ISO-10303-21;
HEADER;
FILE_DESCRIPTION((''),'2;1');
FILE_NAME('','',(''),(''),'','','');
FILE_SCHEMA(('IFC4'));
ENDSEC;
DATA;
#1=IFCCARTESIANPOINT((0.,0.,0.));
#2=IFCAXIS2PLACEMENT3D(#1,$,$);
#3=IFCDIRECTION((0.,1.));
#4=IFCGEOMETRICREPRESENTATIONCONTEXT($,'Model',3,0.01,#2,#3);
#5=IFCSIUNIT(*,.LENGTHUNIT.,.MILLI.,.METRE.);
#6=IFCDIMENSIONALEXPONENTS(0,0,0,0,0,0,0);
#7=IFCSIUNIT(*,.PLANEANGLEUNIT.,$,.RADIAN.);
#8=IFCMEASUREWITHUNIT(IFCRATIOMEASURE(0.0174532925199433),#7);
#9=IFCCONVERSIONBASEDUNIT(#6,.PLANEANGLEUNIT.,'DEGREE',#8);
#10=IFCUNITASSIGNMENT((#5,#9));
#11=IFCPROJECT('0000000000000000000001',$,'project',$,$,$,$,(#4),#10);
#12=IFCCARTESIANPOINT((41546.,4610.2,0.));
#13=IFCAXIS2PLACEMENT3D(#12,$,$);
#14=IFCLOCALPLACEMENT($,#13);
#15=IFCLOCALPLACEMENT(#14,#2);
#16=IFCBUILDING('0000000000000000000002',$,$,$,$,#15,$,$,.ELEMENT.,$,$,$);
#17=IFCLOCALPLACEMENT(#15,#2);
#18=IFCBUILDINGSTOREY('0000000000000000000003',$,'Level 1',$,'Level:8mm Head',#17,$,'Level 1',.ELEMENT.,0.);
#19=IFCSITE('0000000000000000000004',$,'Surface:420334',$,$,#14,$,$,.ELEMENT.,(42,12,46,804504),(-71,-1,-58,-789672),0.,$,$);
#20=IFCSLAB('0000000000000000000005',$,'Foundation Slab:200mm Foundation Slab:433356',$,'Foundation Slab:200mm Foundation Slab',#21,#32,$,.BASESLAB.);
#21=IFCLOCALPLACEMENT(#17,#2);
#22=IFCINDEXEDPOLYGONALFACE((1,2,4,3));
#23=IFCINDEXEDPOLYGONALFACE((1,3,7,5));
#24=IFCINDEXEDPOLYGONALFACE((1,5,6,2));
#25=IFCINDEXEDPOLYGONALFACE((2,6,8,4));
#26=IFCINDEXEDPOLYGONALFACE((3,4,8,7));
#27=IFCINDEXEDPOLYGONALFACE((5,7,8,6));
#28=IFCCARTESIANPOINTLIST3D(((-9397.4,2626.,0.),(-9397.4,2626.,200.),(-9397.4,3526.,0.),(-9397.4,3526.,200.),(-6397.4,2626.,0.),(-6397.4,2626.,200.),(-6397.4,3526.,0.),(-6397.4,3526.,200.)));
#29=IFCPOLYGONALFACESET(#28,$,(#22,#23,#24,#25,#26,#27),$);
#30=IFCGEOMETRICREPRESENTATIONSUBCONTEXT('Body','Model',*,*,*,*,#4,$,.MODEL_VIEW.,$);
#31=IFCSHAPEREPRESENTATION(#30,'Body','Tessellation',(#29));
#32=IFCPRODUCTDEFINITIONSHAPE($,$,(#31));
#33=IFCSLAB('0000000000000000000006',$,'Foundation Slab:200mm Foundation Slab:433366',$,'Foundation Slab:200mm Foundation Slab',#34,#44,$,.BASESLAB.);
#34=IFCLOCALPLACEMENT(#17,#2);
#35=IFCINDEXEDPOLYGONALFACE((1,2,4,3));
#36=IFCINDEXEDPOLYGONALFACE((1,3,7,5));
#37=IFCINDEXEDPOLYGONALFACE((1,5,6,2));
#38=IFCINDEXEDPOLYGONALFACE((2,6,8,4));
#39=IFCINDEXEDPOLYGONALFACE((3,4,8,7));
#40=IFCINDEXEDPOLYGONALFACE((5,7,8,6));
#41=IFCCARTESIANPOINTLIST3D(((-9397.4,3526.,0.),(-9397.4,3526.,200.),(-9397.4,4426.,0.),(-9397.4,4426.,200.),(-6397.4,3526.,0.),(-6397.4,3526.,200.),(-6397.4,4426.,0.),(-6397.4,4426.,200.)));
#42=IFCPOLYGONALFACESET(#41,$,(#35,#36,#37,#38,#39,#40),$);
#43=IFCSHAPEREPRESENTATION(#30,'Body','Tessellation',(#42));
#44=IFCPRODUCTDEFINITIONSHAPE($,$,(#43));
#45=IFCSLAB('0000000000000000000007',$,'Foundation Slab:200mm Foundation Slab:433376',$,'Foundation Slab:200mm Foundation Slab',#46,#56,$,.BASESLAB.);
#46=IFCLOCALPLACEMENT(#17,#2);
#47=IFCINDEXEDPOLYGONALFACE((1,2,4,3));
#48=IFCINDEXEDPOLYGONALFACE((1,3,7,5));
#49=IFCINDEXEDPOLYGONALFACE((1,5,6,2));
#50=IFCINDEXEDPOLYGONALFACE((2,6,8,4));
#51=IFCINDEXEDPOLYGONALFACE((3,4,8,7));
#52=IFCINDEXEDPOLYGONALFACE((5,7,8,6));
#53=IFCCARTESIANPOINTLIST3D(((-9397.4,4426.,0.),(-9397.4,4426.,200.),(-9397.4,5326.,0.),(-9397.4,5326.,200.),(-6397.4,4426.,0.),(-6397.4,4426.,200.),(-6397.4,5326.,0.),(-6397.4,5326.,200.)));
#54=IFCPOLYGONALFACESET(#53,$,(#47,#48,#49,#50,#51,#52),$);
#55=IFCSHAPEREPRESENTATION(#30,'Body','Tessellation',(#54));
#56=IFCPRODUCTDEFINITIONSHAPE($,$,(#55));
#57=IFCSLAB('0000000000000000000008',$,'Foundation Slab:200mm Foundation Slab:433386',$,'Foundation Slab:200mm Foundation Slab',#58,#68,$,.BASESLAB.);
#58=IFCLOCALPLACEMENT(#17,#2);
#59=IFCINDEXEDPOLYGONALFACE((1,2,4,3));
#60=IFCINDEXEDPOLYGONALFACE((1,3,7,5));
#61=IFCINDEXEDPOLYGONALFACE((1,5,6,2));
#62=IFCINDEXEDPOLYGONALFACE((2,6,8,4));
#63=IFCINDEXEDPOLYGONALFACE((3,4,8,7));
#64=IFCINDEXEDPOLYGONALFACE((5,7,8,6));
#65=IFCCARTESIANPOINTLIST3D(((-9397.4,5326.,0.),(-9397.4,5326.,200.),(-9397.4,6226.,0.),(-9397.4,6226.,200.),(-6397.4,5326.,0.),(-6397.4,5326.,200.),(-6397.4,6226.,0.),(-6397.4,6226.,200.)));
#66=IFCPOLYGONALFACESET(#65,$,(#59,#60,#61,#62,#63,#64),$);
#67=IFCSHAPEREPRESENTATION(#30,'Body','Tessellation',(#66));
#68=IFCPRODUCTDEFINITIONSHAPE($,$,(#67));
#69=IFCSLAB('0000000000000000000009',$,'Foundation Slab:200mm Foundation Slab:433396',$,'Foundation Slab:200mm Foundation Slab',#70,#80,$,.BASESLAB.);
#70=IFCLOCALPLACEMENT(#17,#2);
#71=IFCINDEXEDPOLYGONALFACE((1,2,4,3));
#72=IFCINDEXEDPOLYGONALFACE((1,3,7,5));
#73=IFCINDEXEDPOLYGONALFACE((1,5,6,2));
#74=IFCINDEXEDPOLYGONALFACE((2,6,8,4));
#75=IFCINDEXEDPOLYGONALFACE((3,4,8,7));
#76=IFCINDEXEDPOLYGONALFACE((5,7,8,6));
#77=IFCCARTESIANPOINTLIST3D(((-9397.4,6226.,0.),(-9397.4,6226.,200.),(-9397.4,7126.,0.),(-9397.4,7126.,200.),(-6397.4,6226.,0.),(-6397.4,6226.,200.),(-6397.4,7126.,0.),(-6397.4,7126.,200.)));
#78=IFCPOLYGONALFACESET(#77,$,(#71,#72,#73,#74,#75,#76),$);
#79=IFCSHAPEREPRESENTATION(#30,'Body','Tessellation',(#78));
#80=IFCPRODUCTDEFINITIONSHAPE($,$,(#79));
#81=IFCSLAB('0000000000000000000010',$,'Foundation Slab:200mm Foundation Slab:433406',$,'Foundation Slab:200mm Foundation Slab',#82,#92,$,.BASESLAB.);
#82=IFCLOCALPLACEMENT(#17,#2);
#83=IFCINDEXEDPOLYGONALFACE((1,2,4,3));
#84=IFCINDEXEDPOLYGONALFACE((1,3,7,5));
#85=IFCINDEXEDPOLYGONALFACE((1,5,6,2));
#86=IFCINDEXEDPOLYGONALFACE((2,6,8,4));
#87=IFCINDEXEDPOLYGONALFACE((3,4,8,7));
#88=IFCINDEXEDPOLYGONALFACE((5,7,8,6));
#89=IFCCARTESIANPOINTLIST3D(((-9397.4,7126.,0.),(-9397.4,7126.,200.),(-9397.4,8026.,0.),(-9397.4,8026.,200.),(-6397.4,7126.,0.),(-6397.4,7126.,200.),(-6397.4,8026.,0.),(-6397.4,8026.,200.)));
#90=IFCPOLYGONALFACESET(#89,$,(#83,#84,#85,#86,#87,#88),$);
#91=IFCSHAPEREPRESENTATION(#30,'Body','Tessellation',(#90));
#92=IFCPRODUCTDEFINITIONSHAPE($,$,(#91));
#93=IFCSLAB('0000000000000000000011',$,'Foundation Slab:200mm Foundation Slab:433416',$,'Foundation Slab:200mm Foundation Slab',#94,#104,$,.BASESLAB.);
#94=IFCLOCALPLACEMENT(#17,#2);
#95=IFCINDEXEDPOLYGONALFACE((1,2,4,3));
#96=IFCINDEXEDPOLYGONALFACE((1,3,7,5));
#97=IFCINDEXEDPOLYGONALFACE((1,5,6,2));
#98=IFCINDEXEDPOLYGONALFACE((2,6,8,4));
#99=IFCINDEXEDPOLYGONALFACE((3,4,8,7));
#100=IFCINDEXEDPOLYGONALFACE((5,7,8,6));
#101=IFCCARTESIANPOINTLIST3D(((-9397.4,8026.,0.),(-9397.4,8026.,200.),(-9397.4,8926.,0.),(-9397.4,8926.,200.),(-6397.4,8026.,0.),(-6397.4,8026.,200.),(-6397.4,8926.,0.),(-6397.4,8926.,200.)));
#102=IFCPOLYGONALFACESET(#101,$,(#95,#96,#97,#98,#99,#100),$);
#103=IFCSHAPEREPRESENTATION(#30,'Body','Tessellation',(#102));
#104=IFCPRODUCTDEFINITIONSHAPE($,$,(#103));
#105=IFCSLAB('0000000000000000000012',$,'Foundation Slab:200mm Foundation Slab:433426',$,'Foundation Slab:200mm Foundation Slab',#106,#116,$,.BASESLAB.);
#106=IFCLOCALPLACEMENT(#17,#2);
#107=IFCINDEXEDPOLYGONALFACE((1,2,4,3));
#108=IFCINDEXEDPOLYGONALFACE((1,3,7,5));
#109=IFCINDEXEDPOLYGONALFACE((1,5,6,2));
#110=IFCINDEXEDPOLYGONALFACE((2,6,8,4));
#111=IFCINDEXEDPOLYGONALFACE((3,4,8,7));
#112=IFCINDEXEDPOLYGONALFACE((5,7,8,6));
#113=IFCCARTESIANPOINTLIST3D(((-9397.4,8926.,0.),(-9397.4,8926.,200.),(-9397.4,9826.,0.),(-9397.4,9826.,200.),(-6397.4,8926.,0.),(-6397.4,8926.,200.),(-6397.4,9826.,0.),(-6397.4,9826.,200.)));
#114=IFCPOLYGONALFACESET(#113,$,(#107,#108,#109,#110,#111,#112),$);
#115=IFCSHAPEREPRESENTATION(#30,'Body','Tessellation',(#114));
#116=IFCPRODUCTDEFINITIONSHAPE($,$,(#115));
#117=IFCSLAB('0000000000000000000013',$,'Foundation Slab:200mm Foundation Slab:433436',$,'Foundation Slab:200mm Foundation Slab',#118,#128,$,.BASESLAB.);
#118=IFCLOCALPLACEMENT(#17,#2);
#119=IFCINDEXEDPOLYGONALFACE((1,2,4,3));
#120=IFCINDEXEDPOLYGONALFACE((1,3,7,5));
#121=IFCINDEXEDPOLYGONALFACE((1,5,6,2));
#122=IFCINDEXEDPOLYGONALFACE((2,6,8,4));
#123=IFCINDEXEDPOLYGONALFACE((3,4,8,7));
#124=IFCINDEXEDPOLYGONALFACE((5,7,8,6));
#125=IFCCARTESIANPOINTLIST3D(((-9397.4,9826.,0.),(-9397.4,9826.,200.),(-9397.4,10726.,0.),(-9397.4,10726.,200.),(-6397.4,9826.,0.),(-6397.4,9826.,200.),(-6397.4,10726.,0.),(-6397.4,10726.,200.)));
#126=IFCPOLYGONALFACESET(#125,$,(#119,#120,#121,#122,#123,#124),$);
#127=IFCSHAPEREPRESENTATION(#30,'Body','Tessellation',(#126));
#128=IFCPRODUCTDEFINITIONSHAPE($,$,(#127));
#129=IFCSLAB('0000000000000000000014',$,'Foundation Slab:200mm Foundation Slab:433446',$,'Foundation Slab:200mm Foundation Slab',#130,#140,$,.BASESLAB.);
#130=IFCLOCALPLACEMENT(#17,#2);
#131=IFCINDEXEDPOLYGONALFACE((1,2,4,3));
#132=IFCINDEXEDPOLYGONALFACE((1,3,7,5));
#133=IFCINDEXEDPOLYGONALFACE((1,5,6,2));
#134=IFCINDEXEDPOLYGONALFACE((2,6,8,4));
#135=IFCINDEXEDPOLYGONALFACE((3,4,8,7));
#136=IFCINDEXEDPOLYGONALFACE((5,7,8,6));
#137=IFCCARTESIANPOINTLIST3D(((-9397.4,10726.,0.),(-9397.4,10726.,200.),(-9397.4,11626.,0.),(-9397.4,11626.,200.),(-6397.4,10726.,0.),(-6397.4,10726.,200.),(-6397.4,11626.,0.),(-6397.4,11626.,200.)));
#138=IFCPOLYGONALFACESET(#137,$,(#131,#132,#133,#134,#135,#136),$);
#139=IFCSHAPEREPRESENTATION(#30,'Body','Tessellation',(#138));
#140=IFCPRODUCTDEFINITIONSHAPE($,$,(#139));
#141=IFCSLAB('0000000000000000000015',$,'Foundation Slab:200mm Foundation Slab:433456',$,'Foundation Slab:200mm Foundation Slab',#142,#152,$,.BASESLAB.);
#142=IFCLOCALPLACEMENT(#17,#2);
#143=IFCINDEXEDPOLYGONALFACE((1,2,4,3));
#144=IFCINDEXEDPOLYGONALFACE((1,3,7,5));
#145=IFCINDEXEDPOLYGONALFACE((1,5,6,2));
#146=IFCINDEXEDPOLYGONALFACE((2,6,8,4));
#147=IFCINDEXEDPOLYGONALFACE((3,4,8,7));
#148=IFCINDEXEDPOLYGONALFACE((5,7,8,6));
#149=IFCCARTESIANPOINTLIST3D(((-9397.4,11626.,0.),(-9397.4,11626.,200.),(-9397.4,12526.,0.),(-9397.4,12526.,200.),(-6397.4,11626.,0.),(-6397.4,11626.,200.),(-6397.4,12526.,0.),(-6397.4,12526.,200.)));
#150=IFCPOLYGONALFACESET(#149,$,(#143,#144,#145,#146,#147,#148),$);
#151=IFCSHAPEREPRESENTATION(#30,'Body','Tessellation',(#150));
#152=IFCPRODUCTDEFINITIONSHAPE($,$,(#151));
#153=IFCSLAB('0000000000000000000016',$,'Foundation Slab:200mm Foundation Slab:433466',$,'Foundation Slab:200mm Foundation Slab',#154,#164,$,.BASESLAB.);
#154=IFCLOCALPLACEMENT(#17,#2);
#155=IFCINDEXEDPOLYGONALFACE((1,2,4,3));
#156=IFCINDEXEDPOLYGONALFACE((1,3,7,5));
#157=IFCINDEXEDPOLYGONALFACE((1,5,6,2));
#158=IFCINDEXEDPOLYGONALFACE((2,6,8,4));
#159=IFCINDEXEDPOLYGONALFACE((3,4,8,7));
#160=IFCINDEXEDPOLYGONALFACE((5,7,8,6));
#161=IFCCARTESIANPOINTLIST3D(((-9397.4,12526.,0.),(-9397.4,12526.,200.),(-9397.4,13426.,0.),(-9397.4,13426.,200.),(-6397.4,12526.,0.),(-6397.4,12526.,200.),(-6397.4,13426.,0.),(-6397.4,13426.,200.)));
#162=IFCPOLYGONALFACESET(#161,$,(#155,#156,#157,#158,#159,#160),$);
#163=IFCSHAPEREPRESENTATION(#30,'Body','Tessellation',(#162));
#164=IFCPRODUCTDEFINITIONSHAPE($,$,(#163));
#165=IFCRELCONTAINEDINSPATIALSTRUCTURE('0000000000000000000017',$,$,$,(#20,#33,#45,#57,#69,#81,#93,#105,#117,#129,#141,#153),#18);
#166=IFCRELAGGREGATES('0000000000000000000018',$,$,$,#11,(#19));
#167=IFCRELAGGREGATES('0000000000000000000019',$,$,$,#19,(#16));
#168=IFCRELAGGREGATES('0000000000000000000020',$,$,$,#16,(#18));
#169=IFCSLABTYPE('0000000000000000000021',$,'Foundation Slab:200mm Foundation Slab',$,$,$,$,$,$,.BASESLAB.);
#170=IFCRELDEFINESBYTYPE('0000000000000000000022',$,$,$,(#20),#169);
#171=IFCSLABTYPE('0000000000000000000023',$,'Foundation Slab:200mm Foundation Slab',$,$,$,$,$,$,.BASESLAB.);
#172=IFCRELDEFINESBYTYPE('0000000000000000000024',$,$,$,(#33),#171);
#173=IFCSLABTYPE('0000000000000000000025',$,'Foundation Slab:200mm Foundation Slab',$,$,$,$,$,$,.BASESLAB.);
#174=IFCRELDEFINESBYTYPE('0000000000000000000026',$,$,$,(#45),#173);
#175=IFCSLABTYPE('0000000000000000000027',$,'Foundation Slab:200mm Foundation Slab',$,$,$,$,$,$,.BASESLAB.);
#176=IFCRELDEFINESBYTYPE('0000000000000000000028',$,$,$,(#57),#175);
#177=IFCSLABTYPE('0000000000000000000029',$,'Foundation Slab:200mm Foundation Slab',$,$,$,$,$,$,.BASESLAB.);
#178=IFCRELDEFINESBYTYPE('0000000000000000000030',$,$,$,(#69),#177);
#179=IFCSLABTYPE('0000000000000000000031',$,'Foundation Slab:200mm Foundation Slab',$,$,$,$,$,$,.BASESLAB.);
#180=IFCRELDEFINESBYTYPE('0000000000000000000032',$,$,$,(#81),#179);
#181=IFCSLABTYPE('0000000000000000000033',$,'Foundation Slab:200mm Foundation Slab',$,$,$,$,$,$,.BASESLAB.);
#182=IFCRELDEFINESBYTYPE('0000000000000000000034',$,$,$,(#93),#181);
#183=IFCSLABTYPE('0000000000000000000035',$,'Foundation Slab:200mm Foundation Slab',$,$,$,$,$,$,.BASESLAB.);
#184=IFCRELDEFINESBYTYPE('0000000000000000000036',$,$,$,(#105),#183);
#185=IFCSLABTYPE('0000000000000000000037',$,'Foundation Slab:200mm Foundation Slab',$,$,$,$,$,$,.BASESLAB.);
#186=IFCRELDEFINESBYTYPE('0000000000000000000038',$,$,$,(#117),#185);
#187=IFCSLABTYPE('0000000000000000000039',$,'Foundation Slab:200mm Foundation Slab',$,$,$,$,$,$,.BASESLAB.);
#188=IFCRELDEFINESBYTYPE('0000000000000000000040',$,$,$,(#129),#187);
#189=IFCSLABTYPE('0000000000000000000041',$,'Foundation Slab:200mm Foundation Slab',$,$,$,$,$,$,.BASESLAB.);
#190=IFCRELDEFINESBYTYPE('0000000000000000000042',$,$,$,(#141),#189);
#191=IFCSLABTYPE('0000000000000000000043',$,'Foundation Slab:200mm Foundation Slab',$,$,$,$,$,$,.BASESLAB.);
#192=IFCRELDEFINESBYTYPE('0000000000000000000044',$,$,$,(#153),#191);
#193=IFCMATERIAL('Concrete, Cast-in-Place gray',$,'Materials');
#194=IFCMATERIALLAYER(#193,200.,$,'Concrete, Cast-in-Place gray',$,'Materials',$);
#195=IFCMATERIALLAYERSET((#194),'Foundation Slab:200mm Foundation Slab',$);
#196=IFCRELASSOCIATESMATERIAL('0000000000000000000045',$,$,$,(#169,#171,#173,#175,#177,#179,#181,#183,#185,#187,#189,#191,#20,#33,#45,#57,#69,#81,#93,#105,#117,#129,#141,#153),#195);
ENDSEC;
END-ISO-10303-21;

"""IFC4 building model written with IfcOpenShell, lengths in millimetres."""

from ifc_helpers import new_model, entity, si_unit, converted_unit, direction, frame, frame_2d, origin, place, context, subcontext, project, spatial, rectangle, extrude, material, layer, layer_set, layer_usage, type_object, element, save


model = new_model("IFC4")

# Units and contexts
model_context = context("Model", 3, precision=0.01, world=origin(), true_north=direction((0.0, 1.0)))
body_context = subcontext(model_context, "Body", "Model", "MODEL_VIEW")
ifc_project = project(units=[si_unit("LENGTHUNIT", "METRE", prefix="MILLI"), converted_unit("PLANEANGLEUNIT", "DEGREE", entity("IfcRatioMeasure", 0.0174532925199433), si_unit("PLANEANGLEUNIT", "RADIAN"), dimensions=[0, 0, 0, 0, 0, 0, 0])], contexts=[model_context])

# Site, building, storey
site_placement = place(None, frame((41546.0, 4610.2, 0.0)))
site = spatial("IfcSite", under=ifc_project, at=site_placement, Name="Surface:420334", CompositionType="ELEMENT", RefLatitude=(42, 12, 46, 804504), RefLongitude=(-71, -1, -58, -789672), RefElevation=0.0)
building_placement = place(site_placement, origin())
building = spatial("IfcBuilding", under=site, at=building_placement, CompositionType="ELEMENT")
storey_placement = place(building_placement, origin())
storey = spatial("IfcBuildingStorey", under=building, at=storey_placement, Name="Level 1", ObjectType="Level:8mm Head", LongName="Level 1", CompositionType="ELEMENT", Elevation=0.0)

# Slabs
ifc_material = material(Name="Concrete, Cast-in-Place gray", Category="Materials")
ifc_layer = layer(ifc_material, 200.0, Name="Concrete, Cast-in-Place gray", Category="Materials")
ifc_layer_set = layer_set([ifc_layer], Name="Foundation Slab:200mm Foundation Slab")
ifc_layer_usage_1 = layer_usage(ifc_layer_set, "AXIS3", "POSITIVE", 0.0)
slab_type_1 = type_object("IfcSlabType", Name="Foundation Slab:200mm Foundation Slab", PredefinedType="BASESLAB", material=ifc_layer_set)
slab_1_placement = place(storey_placement, origin())
element("IfcSlab", 1, at=slab_1_placement, inside=storey, type_object=slab_type_1, material=ifc_layer_usage_1, Name="Foundation Slab:200mm Foundation Slab:433356", ObjectType="Foundation Slab:200mm Foundation Slab", PredefinedType="BASESLAB", context=body_context, shape_type="SweptSolid", body=[
    extrude(rectangle(XDim=900.0, YDim=3000.0, at=frame_2d((0.0, 0.0), x_axis=(1.0, 0.0))), frame((-7897.4, 3076.0, 200.0), z_axis=(0.0, 0.0, -1.0), x_axis=(0.0, 1.0, 0.0)), (0.0, 0.0, 1.0), 200.0),
])
ifc_layer_usage_2 = layer_usage(ifc_layer_set, "AXIS3", "POSITIVE", 0.0)
slab_type_2 = type_object("IfcSlabType", Name="Foundation Slab:200mm Foundation Slab", PredefinedType="BASESLAB", material=ifc_layer_set)
slab_2_placement = place(storey_placement, origin())
element("IfcSlab", 2, at=slab_2_placement, inside=storey, type_object=slab_type_2, material=ifc_layer_usage_2, Name="Foundation Slab:200mm Foundation Slab:433366", ObjectType="Foundation Slab:200mm Foundation Slab", PredefinedType="BASESLAB", context=body_context, shape_type="SweptSolid", body=[
    extrude(rectangle(XDim=900.0, YDim=3000.0, at=frame_2d((0.0, 0.0), x_axis=(1.0, 0.0))), frame((-7897.4, 3976.0, 200.0), z_axis=(0.0, 0.0, -1.0), x_axis=(0.0, 1.0, 0.0)), (0.0, 0.0, 1.0), 200.0),
])
ifc_layer_usage_3 = layer_usage(ifc_layer_set, "AXIS3", "POSITIVE", 0.0)
slab_type_3 = type_object("IfcSlabType", Name="Foundation Slab:200mm Foundation Slab", PredefinedType="BASESLAB", material=ifc_layer_set)
slab_3_placement = place(storey_placement, origin())
element("IfcSlab", 3, at=slab_3_placement, inside=storey, type_object=slab_type_3, material=ifc_layer_usage_3, Name="Foundation Slab:200mm Foundation Slab:433376", ObjectType="Foundation Slab:200mm Foundation Slab", PredefinedType="BASESLAB", context=body_context, shape_type="SweptSolid", body=[
    extrude(rectangle(XDim=900.0, YDim=3000.0, at=frame_2d((0.0, 0.0), x_axis=(1.0, 0.0))), frame((-7897.4, 4876.0, 200.0), z_axis=(0.0, 0.0, -1.0), x_axis=(0.0, 1.0, 0.0)), (0.0, 0.0, 1.0), 200.0),
])
ifc_layer_usage_4 = layer_usage(ifc_layer_set, "AXIS3", "POSITIVE", 0.0)
slab_type_4 = type_object("IfcSlabType", Name="Foundation Slab:200mm Foundation Slab", PredefinedType="BASESLAB", material=ifc_layer_set)
slab_4_placement = place(storey_placement, origin())
element("IfcSlab", 4, at=slab_4_placement, inside=storey, type_object=slab_type_4, material=ifc_layer_usage_4, Name="Foundation Slab:200mm Foundation Slab:433386", ObjectType="Foundation Slab:200mm Foundation Slab", PredefinedType="BASESLAB", context=body_context, shape_type="SweptSolid", body=[
    extrude(rectangle(XDim=900.0, YDim=3000.0, at=frame_2d((0.0, 0.0), x_axis=(1.0, 0.0))), frame((-7897.4, 5776.0, 200.0), z_axis=(0.0, 0.0, -1.0), x_axis=(0.0, 1.0, 0.0)), (0.0, 0.0, 1.0), 200.0),
])
ifc_layer_usage_5 = layer_usage(ifc_layer_set, "AXIS3", "POSITIVE", 0.0)
slab_type_5 = type_object("IfcSlabType", Name="Foundation Slab:200mm Foundation Slab", PredefinedType="BASESLAB", material=ifc_layer_set)
slab_5_placement = place(storey_placement, origin())
element("IfcSlab", 5, at=slab_5_placement, inside=storey, type_object=slab_type_5, material=ifc_layer_usage_5, Name="Foundation Slab:200mm Foundation Slab:433396", ObjectType="Foundation Slab:200mm Foundation Slab", PredefinedType="BASESLAB", context=body_context, shape_type="SweptSolid", body=[
    extrude(rectangle(XDim=900.0, YDim=3000.0, at=frame_2d((0.0, 0.0), x_axis=(1.0, 0.0))), frame((-7897.4, 6676.0, 200.0), z_axis=(0.0, 0.0, -1.0), x_axis=(0.0, 1.0, 0.0)), (0.0, 0.0, 1.0), 200.0),
])
ifc_layer_usage_6 = layer_usage(ifc_layer_set, "AXIS3", "POSITIVE", 0.0)
slab_type_6 = type_object("IfcSlabType", Name="Foundation Slab:200mm Foundation Slab", PredefinedType="BASESLAB", material=ifc_layer_set)
slab_6_placement = place(storey_placement, origin())
element("IfcSlab", 6, at=slab_6_placement, inside=storey, type_object=slab_type_6, material=ifc_layer_usage_6, Name="Foundation Slab:200mm Foundation Slab:433406", ObjectType="Foundation Slab:200mm Foundation Slab", PredefinedType="BASESLAB", context=body_context, shape_type="SweptSolid", body=[
    extrude(rectangle(XDim=900.0, YDim=3000.0, at=frame_2d((0.0, 0.0), x_axis=(1.0, 0.0))), frame((-7897.4, 7576.0, 200.0), z_axis=(0.0, 0.0, -1.0), x_axis=(0.0, 1.0, 0.0)), (0.0, 0.0, 1.0), 200.0),
])
ifc_layer_usage_7 = layer_usage(ifc_layer_set, "AXIS3", "POSITIVE", 0.0)
slab_type_7 = type_object("IfcSlabType", Name="Foundation Slab:200mm Foundation Slab", PredefinedType="BASESLAB", material=ifc_layer_set)
slab_7_placement = place(storey_placement, origin())
element("IfcSlab", 7, at=slab_7_placement, inside=storey, type_object=slab_type_7, material=ifc_layer_usage_7, Name="Foundation Slab:200mm Foundation Slab:433416", ObjectType="Foundation Slab:200mm Foundation Slab", PredefinedType="BASESLAB", context=body_context, shape_type="SweptSolid", body=[
    extrude(rectangle(XDim=900.0, YDim=3000.0, at=frame_2d((0.0, 0.0), x_axis=(1.0, 0.0))), frame((-7897.4, 8476.0, 200.0), z_axis=(0.0, 0.0, -1.0), x_axis=(0.0, 1.0, 0.0)), (0.0, 0.0, 1.0), 200.0),
])
ifc_layer_usage_8 = layer_usage(ifc_layer_set, "AXIS3", "POSITIVE", 0.0)
slab_type_8 = type_object("IfcSlabType", Name="Foundation Slab:200mm Foundation Slab", PredefinedType="BASESLAB", material=ifc_layer_set)
slab_8_placement = place(storey_placement, origin())
element("IfcSlab", 8, at=slab_8_placement, inside=storey, type_object=slab_type_8, material=ifc_layer_usage_8, Name="Foundation Slab:200mm Foundation Slab:433426", ObjectType="Foundation Slab:200mm Foundation Slab", PredefinedType="BASESLAB", context=body_context, shape_type="SweptSolid", body=[
    extrude(rectangle(XDim=900.0, YDim=3000.0, at=frame_2d((0.0, 0.0), x_axis=(1.0, 0.0))), frame((-7897.4, 9376.0, 200.0), z_axis=(0.0, 0.0, -1.0), x_axis=(0.0, 1.0, 0.0)), (0.0, 0.0, 1.0), 200.0),
])
ifc_layer_usage_9 = layer_usage(ifc_layer_set, "AXIS3", "POSITIVE", 0.0)
slab_type_9 = type_object("IfcSlabType", Name="Foundation Slab:200mm Foundation Slab", PredefinedType="BASESLAB", material=ifc_layer_set)
slab_9_placement = place(storey_placement, origin())
element("IfcSlab", 9, at=slab_9_placement, inside=storey, type_object=slab_type_9, material=ifc_layer_usage_9, Name="Foundation Slab:200mm Foundation Slab:433436", ObjectType="Foundation Slab:200mm Foundation Slab", PredefinedType="BASESLAB", context=body_context, shape_type="SweptSolid", body=[
    extrude(rectangle(XDim=900.0, YDim=3000.0, at=frame_2d((0.0, 0.0), x_axis=(1.0, 0.0))), frame((-7897.4, 10276.0, 200.0), z_axis=(0.0, 0.0, -1.0), x_axis=(0.0, 1.0, 0.0)), (0.0, 0.0, 1.0), 200.0),
])
ifc_layer_usage_10 = layer_usage(ifc_layer_set, "AXIS3", "POSITIVE", 0.0)
slab_type_10 = type_object("IfcSlabType", Name="Foundation Slab:200mm Foundation Slab", PredefinedType="BASESLAB", material=ifc_layer_set)
slab_10_placement = place(storey_placement, origin())
element("IfcSlab", 10, at=slab_10_placement, inside=storey, type_object=slab_type_10, material=ifc_layer_usage_10, Name="Foundation Slab:200mm Foundation Slab:433446", ObjectType="Foundation Slab:200mm Foundation Slab", PredefinedType="BASESLAB", context=body_context, shape_type="SweptSolid", body=[
    extrude(rectangle(XDim=900.0, YDim=3000.0, at=frame_2d((0.0, 0.0), x_axis=(1.0, 0.0))), frame((-7897.4, 11176.0, 200.0), z_axis=(0.0, 0.0, -1.0), x_axis=(0.0, 1.0, 0.0)), (0.0, 0.0, 1.0), 200.0),
])
ifc_layer_usage_11 = layer_usage(ifc_layer_set, "AXIS3", "POSITIVE", 0.0)
slab_type_11 = type_object("IfcSlabType", Name="Foundation Slab:200mm Foundation Slab", PredefinedType="BASESLAB", material=ifc_layer_set)
slab_11_placement = place(storey_placement, origin())
element("IfcSlab", 11, at=slab_11_placement, inside=storey, type_object=slab_type_11, material=ifc_layer_usage_11, Name="Foundation Slab:200mm Foundation Slab:433456", ObjectType="Foundation Slab:200mm Foundation Slab", PredefinedType="BASESLAB", context=body_context, shape_type="SweptSolid", body=[
    extrude(rectangle(XDim=900.0, YDim=3000.0, at=frame_2d((0.0, 0.0), x_axis=(1.0, 0.0))), frame((-7897.4, 12076.0, 200.0), z_axis=(0.0, 0.0, -1.0), x_axis=(0.0, 1.0, 0.0)), (0.0, 0.0, 1.0), 200.0),
])
ifc_layer_usage_12 = layer_usage(ifc_layer_set, "AXIS3", "POSITIVE", 0.0)
slab_type_12 = type_object("IfcSlabType", Name="Foundation Slab:200mm Foundation Slab", PredefinedType="BASESLAB", material=ifc_layer_set)
slab_12_placement = place(storey_placement, origin())
element("IfcSlab", 12, at=slab_12_placement, inside=storey, type_object=slab_type_12, material=ifc_layer_usage_12, Name="Foundation Slab:200mm Foundation Slab:433466", ObjectType="Foundation Slab:200mm Foundation Slab", PredefinedType="BASESLAB", context=body_context, shape_type="SweptSolid", body=[
    extrude(rectangle(XDim=900.0, YDim=3000.0, at=frame_2d((0.0, 0.0), x_axis=(1.0, 0.0))), frame((-7897.4, 12976.0, 200.0), z_axis=(0.0, 0.0, -1.0), x_axis=(0.0, 1.0, 0.0)), (0.0, 0.0, 1.0), 200.0),
])

save(model, "model.ifc")
